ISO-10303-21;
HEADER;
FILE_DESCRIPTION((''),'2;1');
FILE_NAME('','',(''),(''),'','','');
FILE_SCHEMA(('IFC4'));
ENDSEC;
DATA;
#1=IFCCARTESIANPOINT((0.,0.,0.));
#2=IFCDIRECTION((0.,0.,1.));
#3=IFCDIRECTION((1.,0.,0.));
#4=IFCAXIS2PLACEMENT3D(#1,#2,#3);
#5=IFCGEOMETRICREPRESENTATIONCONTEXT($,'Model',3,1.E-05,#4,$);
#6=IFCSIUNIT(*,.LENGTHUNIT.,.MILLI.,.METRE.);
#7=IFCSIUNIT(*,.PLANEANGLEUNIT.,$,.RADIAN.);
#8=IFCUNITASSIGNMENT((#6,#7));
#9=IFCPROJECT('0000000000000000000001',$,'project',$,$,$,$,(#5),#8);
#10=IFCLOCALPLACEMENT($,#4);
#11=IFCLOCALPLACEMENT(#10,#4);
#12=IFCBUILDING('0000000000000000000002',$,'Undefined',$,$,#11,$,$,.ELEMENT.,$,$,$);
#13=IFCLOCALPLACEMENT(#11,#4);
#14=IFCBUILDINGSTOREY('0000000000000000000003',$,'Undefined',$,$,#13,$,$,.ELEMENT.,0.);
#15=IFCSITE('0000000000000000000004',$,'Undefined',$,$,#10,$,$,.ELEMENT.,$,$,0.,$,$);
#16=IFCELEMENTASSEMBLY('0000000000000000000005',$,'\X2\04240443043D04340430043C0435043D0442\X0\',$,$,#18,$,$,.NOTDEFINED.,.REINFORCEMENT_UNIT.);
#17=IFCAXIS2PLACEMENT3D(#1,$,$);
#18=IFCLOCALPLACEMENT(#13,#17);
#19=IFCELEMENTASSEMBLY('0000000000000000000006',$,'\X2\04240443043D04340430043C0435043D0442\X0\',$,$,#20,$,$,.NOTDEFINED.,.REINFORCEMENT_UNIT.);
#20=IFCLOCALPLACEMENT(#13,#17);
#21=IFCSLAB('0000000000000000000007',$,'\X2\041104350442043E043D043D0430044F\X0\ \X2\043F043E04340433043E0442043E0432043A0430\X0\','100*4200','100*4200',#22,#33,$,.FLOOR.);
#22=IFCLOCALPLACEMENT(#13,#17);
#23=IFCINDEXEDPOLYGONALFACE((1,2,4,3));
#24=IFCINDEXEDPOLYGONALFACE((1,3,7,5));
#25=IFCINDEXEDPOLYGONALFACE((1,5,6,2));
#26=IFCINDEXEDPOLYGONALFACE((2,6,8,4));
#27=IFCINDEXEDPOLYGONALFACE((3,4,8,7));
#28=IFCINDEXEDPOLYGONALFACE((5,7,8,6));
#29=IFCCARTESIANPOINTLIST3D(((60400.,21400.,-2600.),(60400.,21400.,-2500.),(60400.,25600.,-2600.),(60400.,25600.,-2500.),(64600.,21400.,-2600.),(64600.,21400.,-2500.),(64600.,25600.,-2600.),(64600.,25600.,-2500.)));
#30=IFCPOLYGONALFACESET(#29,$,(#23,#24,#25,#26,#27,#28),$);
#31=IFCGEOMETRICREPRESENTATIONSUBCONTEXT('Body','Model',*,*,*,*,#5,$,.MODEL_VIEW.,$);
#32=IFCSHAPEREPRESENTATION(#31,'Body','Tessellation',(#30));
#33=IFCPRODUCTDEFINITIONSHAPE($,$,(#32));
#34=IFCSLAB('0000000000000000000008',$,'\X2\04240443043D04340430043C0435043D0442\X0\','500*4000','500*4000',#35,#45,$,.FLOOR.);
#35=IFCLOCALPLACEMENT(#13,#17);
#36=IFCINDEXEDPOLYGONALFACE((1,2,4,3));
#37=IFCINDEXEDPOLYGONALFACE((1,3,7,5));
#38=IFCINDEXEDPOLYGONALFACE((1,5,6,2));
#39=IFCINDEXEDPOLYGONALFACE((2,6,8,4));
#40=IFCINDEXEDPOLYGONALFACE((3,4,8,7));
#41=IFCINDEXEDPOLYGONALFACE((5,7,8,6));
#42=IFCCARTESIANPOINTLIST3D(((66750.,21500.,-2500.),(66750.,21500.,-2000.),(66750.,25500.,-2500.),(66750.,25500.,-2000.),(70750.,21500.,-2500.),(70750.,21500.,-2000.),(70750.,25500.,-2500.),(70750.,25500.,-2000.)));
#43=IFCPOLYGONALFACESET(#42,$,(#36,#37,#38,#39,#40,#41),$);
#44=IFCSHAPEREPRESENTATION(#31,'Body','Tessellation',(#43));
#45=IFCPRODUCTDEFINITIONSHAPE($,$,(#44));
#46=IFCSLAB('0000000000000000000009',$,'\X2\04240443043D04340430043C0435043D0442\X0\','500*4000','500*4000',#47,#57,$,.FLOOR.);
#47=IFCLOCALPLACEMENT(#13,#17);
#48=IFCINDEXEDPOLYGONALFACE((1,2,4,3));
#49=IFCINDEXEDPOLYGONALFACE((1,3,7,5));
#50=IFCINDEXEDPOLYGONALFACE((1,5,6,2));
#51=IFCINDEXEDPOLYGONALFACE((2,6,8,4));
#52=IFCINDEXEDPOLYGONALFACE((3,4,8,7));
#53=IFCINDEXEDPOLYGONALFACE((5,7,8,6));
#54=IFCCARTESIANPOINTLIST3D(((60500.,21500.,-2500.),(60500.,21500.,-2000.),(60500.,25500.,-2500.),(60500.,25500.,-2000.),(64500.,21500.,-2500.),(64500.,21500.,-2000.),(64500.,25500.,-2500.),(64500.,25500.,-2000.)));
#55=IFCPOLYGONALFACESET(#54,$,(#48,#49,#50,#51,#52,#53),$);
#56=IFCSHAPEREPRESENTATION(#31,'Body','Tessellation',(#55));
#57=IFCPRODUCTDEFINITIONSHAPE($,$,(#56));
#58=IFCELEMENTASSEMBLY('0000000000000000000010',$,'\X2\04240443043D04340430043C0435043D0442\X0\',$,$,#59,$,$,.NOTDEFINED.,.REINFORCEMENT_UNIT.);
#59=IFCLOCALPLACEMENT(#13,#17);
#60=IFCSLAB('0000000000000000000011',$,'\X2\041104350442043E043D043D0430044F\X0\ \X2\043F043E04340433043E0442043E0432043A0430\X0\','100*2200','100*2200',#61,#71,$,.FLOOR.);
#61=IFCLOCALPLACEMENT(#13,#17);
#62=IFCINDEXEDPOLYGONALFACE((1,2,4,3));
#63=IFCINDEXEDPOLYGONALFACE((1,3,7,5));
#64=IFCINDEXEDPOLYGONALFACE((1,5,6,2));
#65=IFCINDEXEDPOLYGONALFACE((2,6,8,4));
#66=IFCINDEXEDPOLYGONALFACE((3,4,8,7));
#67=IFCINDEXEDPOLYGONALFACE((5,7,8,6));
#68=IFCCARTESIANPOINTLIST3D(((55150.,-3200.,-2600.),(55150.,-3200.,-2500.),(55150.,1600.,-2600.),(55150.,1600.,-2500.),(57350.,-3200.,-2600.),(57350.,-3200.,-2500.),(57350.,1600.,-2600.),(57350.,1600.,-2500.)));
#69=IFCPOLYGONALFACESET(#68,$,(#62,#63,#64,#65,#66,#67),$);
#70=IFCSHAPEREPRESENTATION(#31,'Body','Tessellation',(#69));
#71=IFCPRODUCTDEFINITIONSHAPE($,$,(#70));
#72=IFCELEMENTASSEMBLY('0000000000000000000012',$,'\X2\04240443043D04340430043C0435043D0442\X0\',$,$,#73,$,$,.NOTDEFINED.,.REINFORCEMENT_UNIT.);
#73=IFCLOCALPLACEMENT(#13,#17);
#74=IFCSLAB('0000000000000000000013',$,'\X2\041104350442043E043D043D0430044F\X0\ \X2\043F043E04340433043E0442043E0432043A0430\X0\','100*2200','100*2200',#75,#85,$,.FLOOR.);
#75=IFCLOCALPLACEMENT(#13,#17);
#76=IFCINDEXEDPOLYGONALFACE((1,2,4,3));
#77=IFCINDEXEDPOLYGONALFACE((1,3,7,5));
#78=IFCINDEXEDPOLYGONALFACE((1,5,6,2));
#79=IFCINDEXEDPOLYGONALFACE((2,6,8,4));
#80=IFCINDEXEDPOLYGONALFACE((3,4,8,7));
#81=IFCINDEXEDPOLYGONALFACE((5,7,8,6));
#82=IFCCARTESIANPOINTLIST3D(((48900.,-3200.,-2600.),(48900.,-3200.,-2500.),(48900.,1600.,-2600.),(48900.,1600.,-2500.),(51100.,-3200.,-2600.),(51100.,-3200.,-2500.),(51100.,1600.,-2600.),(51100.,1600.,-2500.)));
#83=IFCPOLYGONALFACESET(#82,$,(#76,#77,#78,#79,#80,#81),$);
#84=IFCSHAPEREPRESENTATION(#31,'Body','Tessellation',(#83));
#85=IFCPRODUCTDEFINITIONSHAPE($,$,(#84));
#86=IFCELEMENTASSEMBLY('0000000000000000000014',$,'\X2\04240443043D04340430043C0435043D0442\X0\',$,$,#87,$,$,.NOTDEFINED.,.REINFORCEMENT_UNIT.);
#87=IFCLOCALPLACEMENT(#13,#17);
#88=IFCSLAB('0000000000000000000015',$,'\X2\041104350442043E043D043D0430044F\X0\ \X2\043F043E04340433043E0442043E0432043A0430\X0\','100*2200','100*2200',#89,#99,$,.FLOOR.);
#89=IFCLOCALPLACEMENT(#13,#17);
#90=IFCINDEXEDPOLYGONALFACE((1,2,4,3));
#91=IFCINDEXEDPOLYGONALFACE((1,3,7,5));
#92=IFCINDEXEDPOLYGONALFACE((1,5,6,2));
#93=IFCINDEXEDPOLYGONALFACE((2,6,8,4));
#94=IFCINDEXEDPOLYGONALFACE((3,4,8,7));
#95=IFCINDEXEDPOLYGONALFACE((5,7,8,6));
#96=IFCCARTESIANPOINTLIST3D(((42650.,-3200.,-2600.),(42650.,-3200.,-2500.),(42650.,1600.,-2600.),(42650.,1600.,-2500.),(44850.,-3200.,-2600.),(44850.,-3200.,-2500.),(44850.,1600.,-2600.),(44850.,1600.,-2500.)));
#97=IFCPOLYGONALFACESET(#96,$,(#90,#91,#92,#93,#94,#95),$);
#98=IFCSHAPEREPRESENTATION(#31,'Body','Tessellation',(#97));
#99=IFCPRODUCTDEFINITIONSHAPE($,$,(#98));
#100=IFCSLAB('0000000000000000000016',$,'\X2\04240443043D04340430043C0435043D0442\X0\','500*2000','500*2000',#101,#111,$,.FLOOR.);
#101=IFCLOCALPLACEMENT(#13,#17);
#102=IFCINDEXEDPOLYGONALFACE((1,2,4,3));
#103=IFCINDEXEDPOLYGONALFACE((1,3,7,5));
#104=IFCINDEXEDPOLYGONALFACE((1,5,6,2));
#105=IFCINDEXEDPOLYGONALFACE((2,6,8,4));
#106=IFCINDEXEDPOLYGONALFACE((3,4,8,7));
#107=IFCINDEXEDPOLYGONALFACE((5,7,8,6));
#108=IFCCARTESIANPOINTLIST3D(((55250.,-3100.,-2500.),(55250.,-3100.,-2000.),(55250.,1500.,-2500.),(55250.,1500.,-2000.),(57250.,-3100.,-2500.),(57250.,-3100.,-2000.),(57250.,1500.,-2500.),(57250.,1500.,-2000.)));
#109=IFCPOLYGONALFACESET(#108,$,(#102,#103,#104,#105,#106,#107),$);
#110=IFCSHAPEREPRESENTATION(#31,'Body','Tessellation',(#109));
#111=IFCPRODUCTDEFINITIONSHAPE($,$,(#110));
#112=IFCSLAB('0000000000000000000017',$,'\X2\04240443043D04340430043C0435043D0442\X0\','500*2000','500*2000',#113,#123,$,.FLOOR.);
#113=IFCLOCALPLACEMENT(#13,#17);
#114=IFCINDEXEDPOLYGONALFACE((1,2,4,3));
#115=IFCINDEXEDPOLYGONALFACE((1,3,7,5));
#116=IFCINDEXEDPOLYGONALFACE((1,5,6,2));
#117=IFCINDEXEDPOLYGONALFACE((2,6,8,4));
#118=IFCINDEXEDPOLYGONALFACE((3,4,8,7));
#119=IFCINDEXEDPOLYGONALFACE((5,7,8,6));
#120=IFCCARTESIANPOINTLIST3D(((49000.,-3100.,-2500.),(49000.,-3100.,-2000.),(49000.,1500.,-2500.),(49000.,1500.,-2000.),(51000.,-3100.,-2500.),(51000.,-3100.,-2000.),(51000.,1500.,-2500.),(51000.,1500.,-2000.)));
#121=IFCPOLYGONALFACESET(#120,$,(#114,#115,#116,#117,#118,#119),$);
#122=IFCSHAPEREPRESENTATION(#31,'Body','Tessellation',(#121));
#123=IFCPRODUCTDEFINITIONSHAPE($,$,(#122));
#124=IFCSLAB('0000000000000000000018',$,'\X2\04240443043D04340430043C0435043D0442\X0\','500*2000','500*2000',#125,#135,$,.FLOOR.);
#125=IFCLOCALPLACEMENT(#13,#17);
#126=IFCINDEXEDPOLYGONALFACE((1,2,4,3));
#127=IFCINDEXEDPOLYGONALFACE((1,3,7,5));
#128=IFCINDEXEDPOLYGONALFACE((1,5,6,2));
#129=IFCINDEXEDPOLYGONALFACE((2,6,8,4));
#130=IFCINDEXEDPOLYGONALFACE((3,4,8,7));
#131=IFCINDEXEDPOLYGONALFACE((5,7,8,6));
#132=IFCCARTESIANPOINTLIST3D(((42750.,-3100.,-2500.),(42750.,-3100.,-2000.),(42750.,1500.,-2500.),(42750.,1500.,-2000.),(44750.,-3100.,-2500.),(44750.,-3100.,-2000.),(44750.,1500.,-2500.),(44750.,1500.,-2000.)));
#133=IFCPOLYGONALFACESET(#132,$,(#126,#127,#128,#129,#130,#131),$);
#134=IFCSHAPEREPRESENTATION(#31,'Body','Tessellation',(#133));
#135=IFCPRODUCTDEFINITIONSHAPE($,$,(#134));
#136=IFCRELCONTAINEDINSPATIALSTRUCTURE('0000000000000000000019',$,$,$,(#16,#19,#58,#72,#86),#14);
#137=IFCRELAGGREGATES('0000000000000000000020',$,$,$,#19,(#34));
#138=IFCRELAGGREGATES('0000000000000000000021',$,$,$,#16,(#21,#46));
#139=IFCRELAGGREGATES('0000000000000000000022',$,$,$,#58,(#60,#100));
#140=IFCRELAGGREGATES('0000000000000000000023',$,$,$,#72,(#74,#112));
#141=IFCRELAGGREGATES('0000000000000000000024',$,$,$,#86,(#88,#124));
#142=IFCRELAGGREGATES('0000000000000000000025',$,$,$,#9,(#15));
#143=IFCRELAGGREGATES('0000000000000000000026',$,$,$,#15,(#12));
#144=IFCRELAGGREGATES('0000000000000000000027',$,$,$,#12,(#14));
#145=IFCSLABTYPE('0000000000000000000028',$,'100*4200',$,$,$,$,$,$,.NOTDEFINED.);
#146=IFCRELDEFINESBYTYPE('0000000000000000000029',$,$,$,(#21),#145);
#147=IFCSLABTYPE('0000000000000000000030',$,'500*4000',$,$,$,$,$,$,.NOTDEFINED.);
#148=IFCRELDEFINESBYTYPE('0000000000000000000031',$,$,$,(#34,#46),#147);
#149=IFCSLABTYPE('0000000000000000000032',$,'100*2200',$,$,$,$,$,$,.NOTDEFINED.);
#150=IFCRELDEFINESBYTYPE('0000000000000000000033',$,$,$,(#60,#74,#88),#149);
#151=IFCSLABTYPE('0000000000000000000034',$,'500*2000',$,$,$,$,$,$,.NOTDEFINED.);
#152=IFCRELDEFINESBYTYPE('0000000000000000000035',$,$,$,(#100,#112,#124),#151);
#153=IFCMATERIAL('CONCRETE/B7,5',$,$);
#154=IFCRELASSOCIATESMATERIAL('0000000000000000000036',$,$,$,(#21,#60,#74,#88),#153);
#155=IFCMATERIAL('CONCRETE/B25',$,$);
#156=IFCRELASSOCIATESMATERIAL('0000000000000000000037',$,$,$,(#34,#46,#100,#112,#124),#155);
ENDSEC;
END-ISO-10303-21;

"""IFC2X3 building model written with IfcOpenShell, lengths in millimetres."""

from ifc_helpers import new_model, si_unit, frame, origin_with_axes, place, context, subcontext, project, spatial, polyline, outline, extrude, material, type_object, element, aggregate, save


model = new_model("IFC2X3")

# Units and contexts
model_context = context("Model", 3, precision=1e-05, world=origin_with_axes())
body_context = subcontext(model_context, "Body", "Model", "MODEL_VIEW")
ifc_project = project(units=[si_unit("LENGTHUNIT", "METRE", prefix="MILLI"), si_unit("PLANEANGLEUNIT", "RADIAN")], contexts=[model_context])

# Site, building, storey
site_placement = place(None, origin_with_axes())
site = spatial("IfcSite", under=ifc_project, at=site_placement, Name="Undefined", CompositionType="ELEMENT", RefElevation=0.0)
building_placement = place(site_placement, origin_with_axes())
building = spatial("IfcBuilding", under=site, at=building_placement, Name="Undefined", CompositionType="ELEMENT")
storey_placement = place(building_placement, origin_with_axes())
storey = spatial("IfcBuildingStorey", under=building, at=storey_placement, Name="Undefined", CompositionType="ELEMENT", Elevation=0.0)

# Element assembly
assembly_1_placement = place(storey_placement, origin_with_axes())
assembly_1 = element("IfcElementAssembly", 1, at=assembly_1_placement, inside=storey, Name="Фундамент", AssemblyPlace="NOTDEFINED", PredefinedType="REINFORCEMENT_UNIT")
ifc_material_1 = material(Name="CONCRETE/B25")

# Element assembly
assembly_2_placement = place(storey_placement, origin_with_axes())
assembly_2 = element("IfcElementAssembly", 2, at=assembly_2_placement, inside=storey, Name="Фундамент", AssemblyPlace="NOTDEFINED", PredefinedType="REINFORCEMENT_UNIT")

# Shared definitions
ifc_material_2 = material(Name="CONCRETE/B7,5")

# Slabs
slab_type_1 = type_object("IfcSlabType", Name="100*4200", PredefinedType="NOTDEFINED")
slab_1_placement = place(assembly_1_placement, frame((60400.0, 25600.0, -2550.0), z_axis=(0.0, 0.0, 1.0), x_axis=(0.0, -1.0, 0.0)))
slab_1 = element("IfcSlab", 3, at=slab_1_placement, type_object=slab_type_1, material=ifc_material_2, Name="Бетонная подготовка", Description="100*4200", ObjectType="100*4200", PredefinedType="FLOOR", context=body_context, shape_type="SweptSolid", body=[
    extrude(outline(polyline([(0.0, 0.0), (4200.0, 0.0), (4200.0, 4200.0), (0.0, 4200.0), (0.0, 0.0)])), frame((0.0, 0.0, -50.0), z_axis=(0.0, 0.0, 1.0), x_axis=(1.0, 0.0, 0.0)), (0.0, 0.0, 1.0), 100.0),
])
slab_type_2 = type_object("IfcSlabType", Name="500*4000", PredefinedType="NOTDEFINED")
slab_2_placement = place(assembly_2_placement, frame((66750.0, 25500.0, -2250.0), z_axis=(0.0, 0.0, 1.0), x_axis=(0.0, -1.0, 0.0)))
slab_2 = element("IfcSlab", 4, at=slab_2_placement, type_object=slab_type_2, material=ifc_material_1, Name="Фундамент", Description="500*4000", ObjectType="500*4000", PredefinedType="FLOOR", context=body_context, shape_type="SweptSolid", body=[
    extrude(outline(polyline([(0.0, 0.0), (4000.0, 0.0), (4000.0, 4000.0), (0.0, 4000.0), (0.0, 0.0)])), frame((0.0, 0.0, -250.0), z_axis=(0.0, 0.0, 1.0), x_axis=(1.0, 0.0, 0.0)), (0.0, 0.0, 1.0), 500.0),
])
aggregate(assembly_2, [slab_2])
slab_3_placement = place(assembly_1_placement, frame((60500.0, 25500.0, -2250.0), z_axis=(0.0, 0.0, 1.0), x_axis=(0.0, -1.0, 0.0)))
slab_3 = element("IfcSlab", 5, at=slab_3_placement, type_object=slab_type_2, material=ifc_material_1, Name="Фундамент", Description="500*4000", ObjectType="500*4000", PredefinedType="FLOOR", context=body_context, shape_type="SweptSolid", body=[
    extrude(outline(polyline([(0.0, 0.0), (4000.0, 0.0), (4000.0, 4000.0), (0.0, 4000.0), (0.0, 0.0)])), frame((0.0, 0.0, -250.0), z_axis=(0.0, 0.0, 1.0), x_axis=(1.0, 0.0, 0.0)), (0.0, 0.0, 1.0), 500.0),
])
aggregate(assembly_1, [slab_1, slab_3])

# Element assemblies, slabs
assembly_3_placement = place(storey_placement, origin_with_axes())
assembly_3 = element("IfcElementAssembly", 6, at=assembly_3_placement, inside=storey, Name="Фундамент", AssemblyPlace="NOTDEFINED", PredefinedType="REINFORCEMENT_UNIT")
slab_type_3 = type_object("IfcSlabType", Name="100*2200", PredefinedType="NOTDEFINED")
slab_4_placement = place(assembly_3_placement, frame((55150.0, 1600.0, -2550.0), z_axis=(0.0, 0.0, 1.0), x_axis=(0.0, -1.0, 0.0)))
slab_4 = element("IfcSlab", 7, at=slab_4_placement, type_object=slab_type_3, material=ifc_material_2, Name="Бетонная подготовка", Description="100*2200", ObjectType="100*2200", PredefinedType="FLOOR", context=body_context, shape_type="SweptSolid", body=[
    extrude(outline(polyline([(0.0, 0.0), (4800.0, 0.0), (4800.0, 2200.0), (0.0, 2200.0), (0.0, 0.0)])), frame((0.0, 0.0, -50.0), z_axis=(0.0, 0.0, 1.0), x_axis=(1.0, 0.0, 0.0)), (0.0, 0.0, 1.0), 100.0),
])
assembly_4_placement = place(storey_placement, origin_with_axes())
assembly_4 = element("IfcElementAssembly", 8, at=assembly_4_placement, inside=storey, Name="Фундамент", AssemblyPlace="NOTDEFINED", PredefinedType="REINFORCEMENT_UNIT")
slab_5_placement = place(assembly_4_placement, frame((48900.0, 1600.0, -2550.0), z_axis=(0.0, 0.0, 1.0), x_axis=(0.0, -1.0, 0.0)))
slab_5 = element("IfcSlab", 9, at=slab_5_placement, type_object=slab_type_3, material=ifc_material_2, Name="Бетонная подготовка", Description="100*2200", ObjectType="100*2200", PredefinedType="FLOOR", context=body_context, shape_type="SweptSolid", body=[
    extrude(outline(polyline([(0.0, 0.0), (4800.0, 0.0), (4800.0, 2200.0), (0.0, 2200.0), (0.0, 0.0)])), frame((0.0, 0.0, -50.0), z_axis=(0.0, 0.0, 1.0), x_axis=(1.0, 0.0, 0.0)), (0.0, 0.0, 1.0), 100.0),
])
assembly_5_placement = place(storey_placement, origin_with_axes())
assembly_5 = element("IfcElementAssembly", 10, at=assembly_5_placement, inside=storey, Name="Фундамент", AssemblyPlace="NOTDEFINED", PredefinedType="REINFORCEMENT_UNIT")
slab_6_placement = place(assembly_5_placement, frame((42650.0, 1600.0, -2550.0), z_axis=(0.0, 0.0, 1.0), x_axis=(0.0, -1.0, 0.0)))
slab_6 = element("IfcSlab", 11, at=slab_6_placement, type_object=slab_type_3, material=ifc_material_2, Name="Бетонная подготовка", Description="100*2200", ObjectType="100*2200", PredefinedType="FLOOR", context=body_context, shape_type="SweptSolid", body=[
    extrude(outline(polyline([(0.0, 0.0), (4800.0, 0.0), (4800.0, 2200.0), (0.0, 2200.0), (0.0, 0.0)])), frame((0.0, 0.0, -50.0), z_axis=(0.0, 0.0, 1.0), x_axis=(1.0, 0.0, 0.0)), (0.0, 0.0, 1.0), 100.0),
])

# Slabs
slab_type_4 = type_object("IfcSlabType", Name="500*2000", PredefinedType="NOTDEFINED")
slab_7_placement = place(assembly_3_placement, frame((55250.0, 1500.0, -2250.0), z_axis=(0.0, 0.0, 1.0), x_axis=(0.0, -1.0, 0.0)))
slab_7 = element("IfcSlab", 12, at=slab_7_placement, type_object=slab_type_4, material=ifc_material_1, Name="Фундамент", Description="500*2000", ObjectType="500*2000", PredefinedType="FLOOR", context=body_context, shape_type="SweptSolid", body=[
    extrude(outline(polyline([(0.0, 0.0), (4600.0, 0.0), (4600.0, 2000.0), (0.0, 2000.0), (0.0, 0.0)])), frame((0.0, 0.0, -250.0), z_axis=(0.0, 0.0, 1.0), x_axis=(1.0, 0.0, 0.0)), (0.0, 0.0, 1.0), 500.0),
])
aggregate(assembly_3, [slab_4, slab_7])
slab_8_placement = place(assembly_4_placement, frame((49000.0, 1500.0, -2250.0), z_axis=(0.0, 0.0, 1.0), x_axis=(0.0, -1.0, 0.0)))
slab_8 = element("IfcSlab", 13, at=slab_8_placement, type_object=slab_type_4, material=ifc_material_1, Name="Фундамент", Description="500*2000", ObjectType="500*2000", PredefinedType="FLOOR", context=body_context, shape_type="SweptSolid", body=[
    extrude(outline(polyline([(0.0, 0.0), (4600.0, 0.0), (4600.0, 2000.0), (0.0, 2000.0), (0.0, 0.0)])), frame((0.0, 0.0, -250.0), z_axis=(0.0, 0.0, 1.0), x_axis=(1.0, 0.0, 0.0)), (0.0, 0.0, 1.0), 500.0),
])
aggregate(assembly_4, [slab_5, slab_8])
slab_9_placement = place(assembly_5_placement, frame((42750.0, 1500.0, -2250.0), z_axis=(0.0, 0.0, 1.0), x_axis=(0.0, -1.0, 0.0)))
slab_9 = element("IfcSlab", 14, at=slab_9_placement, type_object=slab_type_4, material=ifc_material_1, Name="Фундамент", Description="500*2000", ObjectType="500*2000", PredefinedType="FLOOR", context=body_context, shape_type="SweptSolid", body=[
    extrude(outline(polyline([(0.0, 0.0), (4600.0, 0.0), (4600.0, 2000.0), (0.0, 2000.0), (0.0, 0.0)])), frame((0.0, 0.0, -250.0), z_axis=(0.0, 0.0, 1.0), x_axis=(1.0, 0.0, 0.0)), (0.0, 0.0, 1.0), 500.0),
])
aggregate(assembly_5, [slab_6, slab_9])

save(model, "model.ifc")
